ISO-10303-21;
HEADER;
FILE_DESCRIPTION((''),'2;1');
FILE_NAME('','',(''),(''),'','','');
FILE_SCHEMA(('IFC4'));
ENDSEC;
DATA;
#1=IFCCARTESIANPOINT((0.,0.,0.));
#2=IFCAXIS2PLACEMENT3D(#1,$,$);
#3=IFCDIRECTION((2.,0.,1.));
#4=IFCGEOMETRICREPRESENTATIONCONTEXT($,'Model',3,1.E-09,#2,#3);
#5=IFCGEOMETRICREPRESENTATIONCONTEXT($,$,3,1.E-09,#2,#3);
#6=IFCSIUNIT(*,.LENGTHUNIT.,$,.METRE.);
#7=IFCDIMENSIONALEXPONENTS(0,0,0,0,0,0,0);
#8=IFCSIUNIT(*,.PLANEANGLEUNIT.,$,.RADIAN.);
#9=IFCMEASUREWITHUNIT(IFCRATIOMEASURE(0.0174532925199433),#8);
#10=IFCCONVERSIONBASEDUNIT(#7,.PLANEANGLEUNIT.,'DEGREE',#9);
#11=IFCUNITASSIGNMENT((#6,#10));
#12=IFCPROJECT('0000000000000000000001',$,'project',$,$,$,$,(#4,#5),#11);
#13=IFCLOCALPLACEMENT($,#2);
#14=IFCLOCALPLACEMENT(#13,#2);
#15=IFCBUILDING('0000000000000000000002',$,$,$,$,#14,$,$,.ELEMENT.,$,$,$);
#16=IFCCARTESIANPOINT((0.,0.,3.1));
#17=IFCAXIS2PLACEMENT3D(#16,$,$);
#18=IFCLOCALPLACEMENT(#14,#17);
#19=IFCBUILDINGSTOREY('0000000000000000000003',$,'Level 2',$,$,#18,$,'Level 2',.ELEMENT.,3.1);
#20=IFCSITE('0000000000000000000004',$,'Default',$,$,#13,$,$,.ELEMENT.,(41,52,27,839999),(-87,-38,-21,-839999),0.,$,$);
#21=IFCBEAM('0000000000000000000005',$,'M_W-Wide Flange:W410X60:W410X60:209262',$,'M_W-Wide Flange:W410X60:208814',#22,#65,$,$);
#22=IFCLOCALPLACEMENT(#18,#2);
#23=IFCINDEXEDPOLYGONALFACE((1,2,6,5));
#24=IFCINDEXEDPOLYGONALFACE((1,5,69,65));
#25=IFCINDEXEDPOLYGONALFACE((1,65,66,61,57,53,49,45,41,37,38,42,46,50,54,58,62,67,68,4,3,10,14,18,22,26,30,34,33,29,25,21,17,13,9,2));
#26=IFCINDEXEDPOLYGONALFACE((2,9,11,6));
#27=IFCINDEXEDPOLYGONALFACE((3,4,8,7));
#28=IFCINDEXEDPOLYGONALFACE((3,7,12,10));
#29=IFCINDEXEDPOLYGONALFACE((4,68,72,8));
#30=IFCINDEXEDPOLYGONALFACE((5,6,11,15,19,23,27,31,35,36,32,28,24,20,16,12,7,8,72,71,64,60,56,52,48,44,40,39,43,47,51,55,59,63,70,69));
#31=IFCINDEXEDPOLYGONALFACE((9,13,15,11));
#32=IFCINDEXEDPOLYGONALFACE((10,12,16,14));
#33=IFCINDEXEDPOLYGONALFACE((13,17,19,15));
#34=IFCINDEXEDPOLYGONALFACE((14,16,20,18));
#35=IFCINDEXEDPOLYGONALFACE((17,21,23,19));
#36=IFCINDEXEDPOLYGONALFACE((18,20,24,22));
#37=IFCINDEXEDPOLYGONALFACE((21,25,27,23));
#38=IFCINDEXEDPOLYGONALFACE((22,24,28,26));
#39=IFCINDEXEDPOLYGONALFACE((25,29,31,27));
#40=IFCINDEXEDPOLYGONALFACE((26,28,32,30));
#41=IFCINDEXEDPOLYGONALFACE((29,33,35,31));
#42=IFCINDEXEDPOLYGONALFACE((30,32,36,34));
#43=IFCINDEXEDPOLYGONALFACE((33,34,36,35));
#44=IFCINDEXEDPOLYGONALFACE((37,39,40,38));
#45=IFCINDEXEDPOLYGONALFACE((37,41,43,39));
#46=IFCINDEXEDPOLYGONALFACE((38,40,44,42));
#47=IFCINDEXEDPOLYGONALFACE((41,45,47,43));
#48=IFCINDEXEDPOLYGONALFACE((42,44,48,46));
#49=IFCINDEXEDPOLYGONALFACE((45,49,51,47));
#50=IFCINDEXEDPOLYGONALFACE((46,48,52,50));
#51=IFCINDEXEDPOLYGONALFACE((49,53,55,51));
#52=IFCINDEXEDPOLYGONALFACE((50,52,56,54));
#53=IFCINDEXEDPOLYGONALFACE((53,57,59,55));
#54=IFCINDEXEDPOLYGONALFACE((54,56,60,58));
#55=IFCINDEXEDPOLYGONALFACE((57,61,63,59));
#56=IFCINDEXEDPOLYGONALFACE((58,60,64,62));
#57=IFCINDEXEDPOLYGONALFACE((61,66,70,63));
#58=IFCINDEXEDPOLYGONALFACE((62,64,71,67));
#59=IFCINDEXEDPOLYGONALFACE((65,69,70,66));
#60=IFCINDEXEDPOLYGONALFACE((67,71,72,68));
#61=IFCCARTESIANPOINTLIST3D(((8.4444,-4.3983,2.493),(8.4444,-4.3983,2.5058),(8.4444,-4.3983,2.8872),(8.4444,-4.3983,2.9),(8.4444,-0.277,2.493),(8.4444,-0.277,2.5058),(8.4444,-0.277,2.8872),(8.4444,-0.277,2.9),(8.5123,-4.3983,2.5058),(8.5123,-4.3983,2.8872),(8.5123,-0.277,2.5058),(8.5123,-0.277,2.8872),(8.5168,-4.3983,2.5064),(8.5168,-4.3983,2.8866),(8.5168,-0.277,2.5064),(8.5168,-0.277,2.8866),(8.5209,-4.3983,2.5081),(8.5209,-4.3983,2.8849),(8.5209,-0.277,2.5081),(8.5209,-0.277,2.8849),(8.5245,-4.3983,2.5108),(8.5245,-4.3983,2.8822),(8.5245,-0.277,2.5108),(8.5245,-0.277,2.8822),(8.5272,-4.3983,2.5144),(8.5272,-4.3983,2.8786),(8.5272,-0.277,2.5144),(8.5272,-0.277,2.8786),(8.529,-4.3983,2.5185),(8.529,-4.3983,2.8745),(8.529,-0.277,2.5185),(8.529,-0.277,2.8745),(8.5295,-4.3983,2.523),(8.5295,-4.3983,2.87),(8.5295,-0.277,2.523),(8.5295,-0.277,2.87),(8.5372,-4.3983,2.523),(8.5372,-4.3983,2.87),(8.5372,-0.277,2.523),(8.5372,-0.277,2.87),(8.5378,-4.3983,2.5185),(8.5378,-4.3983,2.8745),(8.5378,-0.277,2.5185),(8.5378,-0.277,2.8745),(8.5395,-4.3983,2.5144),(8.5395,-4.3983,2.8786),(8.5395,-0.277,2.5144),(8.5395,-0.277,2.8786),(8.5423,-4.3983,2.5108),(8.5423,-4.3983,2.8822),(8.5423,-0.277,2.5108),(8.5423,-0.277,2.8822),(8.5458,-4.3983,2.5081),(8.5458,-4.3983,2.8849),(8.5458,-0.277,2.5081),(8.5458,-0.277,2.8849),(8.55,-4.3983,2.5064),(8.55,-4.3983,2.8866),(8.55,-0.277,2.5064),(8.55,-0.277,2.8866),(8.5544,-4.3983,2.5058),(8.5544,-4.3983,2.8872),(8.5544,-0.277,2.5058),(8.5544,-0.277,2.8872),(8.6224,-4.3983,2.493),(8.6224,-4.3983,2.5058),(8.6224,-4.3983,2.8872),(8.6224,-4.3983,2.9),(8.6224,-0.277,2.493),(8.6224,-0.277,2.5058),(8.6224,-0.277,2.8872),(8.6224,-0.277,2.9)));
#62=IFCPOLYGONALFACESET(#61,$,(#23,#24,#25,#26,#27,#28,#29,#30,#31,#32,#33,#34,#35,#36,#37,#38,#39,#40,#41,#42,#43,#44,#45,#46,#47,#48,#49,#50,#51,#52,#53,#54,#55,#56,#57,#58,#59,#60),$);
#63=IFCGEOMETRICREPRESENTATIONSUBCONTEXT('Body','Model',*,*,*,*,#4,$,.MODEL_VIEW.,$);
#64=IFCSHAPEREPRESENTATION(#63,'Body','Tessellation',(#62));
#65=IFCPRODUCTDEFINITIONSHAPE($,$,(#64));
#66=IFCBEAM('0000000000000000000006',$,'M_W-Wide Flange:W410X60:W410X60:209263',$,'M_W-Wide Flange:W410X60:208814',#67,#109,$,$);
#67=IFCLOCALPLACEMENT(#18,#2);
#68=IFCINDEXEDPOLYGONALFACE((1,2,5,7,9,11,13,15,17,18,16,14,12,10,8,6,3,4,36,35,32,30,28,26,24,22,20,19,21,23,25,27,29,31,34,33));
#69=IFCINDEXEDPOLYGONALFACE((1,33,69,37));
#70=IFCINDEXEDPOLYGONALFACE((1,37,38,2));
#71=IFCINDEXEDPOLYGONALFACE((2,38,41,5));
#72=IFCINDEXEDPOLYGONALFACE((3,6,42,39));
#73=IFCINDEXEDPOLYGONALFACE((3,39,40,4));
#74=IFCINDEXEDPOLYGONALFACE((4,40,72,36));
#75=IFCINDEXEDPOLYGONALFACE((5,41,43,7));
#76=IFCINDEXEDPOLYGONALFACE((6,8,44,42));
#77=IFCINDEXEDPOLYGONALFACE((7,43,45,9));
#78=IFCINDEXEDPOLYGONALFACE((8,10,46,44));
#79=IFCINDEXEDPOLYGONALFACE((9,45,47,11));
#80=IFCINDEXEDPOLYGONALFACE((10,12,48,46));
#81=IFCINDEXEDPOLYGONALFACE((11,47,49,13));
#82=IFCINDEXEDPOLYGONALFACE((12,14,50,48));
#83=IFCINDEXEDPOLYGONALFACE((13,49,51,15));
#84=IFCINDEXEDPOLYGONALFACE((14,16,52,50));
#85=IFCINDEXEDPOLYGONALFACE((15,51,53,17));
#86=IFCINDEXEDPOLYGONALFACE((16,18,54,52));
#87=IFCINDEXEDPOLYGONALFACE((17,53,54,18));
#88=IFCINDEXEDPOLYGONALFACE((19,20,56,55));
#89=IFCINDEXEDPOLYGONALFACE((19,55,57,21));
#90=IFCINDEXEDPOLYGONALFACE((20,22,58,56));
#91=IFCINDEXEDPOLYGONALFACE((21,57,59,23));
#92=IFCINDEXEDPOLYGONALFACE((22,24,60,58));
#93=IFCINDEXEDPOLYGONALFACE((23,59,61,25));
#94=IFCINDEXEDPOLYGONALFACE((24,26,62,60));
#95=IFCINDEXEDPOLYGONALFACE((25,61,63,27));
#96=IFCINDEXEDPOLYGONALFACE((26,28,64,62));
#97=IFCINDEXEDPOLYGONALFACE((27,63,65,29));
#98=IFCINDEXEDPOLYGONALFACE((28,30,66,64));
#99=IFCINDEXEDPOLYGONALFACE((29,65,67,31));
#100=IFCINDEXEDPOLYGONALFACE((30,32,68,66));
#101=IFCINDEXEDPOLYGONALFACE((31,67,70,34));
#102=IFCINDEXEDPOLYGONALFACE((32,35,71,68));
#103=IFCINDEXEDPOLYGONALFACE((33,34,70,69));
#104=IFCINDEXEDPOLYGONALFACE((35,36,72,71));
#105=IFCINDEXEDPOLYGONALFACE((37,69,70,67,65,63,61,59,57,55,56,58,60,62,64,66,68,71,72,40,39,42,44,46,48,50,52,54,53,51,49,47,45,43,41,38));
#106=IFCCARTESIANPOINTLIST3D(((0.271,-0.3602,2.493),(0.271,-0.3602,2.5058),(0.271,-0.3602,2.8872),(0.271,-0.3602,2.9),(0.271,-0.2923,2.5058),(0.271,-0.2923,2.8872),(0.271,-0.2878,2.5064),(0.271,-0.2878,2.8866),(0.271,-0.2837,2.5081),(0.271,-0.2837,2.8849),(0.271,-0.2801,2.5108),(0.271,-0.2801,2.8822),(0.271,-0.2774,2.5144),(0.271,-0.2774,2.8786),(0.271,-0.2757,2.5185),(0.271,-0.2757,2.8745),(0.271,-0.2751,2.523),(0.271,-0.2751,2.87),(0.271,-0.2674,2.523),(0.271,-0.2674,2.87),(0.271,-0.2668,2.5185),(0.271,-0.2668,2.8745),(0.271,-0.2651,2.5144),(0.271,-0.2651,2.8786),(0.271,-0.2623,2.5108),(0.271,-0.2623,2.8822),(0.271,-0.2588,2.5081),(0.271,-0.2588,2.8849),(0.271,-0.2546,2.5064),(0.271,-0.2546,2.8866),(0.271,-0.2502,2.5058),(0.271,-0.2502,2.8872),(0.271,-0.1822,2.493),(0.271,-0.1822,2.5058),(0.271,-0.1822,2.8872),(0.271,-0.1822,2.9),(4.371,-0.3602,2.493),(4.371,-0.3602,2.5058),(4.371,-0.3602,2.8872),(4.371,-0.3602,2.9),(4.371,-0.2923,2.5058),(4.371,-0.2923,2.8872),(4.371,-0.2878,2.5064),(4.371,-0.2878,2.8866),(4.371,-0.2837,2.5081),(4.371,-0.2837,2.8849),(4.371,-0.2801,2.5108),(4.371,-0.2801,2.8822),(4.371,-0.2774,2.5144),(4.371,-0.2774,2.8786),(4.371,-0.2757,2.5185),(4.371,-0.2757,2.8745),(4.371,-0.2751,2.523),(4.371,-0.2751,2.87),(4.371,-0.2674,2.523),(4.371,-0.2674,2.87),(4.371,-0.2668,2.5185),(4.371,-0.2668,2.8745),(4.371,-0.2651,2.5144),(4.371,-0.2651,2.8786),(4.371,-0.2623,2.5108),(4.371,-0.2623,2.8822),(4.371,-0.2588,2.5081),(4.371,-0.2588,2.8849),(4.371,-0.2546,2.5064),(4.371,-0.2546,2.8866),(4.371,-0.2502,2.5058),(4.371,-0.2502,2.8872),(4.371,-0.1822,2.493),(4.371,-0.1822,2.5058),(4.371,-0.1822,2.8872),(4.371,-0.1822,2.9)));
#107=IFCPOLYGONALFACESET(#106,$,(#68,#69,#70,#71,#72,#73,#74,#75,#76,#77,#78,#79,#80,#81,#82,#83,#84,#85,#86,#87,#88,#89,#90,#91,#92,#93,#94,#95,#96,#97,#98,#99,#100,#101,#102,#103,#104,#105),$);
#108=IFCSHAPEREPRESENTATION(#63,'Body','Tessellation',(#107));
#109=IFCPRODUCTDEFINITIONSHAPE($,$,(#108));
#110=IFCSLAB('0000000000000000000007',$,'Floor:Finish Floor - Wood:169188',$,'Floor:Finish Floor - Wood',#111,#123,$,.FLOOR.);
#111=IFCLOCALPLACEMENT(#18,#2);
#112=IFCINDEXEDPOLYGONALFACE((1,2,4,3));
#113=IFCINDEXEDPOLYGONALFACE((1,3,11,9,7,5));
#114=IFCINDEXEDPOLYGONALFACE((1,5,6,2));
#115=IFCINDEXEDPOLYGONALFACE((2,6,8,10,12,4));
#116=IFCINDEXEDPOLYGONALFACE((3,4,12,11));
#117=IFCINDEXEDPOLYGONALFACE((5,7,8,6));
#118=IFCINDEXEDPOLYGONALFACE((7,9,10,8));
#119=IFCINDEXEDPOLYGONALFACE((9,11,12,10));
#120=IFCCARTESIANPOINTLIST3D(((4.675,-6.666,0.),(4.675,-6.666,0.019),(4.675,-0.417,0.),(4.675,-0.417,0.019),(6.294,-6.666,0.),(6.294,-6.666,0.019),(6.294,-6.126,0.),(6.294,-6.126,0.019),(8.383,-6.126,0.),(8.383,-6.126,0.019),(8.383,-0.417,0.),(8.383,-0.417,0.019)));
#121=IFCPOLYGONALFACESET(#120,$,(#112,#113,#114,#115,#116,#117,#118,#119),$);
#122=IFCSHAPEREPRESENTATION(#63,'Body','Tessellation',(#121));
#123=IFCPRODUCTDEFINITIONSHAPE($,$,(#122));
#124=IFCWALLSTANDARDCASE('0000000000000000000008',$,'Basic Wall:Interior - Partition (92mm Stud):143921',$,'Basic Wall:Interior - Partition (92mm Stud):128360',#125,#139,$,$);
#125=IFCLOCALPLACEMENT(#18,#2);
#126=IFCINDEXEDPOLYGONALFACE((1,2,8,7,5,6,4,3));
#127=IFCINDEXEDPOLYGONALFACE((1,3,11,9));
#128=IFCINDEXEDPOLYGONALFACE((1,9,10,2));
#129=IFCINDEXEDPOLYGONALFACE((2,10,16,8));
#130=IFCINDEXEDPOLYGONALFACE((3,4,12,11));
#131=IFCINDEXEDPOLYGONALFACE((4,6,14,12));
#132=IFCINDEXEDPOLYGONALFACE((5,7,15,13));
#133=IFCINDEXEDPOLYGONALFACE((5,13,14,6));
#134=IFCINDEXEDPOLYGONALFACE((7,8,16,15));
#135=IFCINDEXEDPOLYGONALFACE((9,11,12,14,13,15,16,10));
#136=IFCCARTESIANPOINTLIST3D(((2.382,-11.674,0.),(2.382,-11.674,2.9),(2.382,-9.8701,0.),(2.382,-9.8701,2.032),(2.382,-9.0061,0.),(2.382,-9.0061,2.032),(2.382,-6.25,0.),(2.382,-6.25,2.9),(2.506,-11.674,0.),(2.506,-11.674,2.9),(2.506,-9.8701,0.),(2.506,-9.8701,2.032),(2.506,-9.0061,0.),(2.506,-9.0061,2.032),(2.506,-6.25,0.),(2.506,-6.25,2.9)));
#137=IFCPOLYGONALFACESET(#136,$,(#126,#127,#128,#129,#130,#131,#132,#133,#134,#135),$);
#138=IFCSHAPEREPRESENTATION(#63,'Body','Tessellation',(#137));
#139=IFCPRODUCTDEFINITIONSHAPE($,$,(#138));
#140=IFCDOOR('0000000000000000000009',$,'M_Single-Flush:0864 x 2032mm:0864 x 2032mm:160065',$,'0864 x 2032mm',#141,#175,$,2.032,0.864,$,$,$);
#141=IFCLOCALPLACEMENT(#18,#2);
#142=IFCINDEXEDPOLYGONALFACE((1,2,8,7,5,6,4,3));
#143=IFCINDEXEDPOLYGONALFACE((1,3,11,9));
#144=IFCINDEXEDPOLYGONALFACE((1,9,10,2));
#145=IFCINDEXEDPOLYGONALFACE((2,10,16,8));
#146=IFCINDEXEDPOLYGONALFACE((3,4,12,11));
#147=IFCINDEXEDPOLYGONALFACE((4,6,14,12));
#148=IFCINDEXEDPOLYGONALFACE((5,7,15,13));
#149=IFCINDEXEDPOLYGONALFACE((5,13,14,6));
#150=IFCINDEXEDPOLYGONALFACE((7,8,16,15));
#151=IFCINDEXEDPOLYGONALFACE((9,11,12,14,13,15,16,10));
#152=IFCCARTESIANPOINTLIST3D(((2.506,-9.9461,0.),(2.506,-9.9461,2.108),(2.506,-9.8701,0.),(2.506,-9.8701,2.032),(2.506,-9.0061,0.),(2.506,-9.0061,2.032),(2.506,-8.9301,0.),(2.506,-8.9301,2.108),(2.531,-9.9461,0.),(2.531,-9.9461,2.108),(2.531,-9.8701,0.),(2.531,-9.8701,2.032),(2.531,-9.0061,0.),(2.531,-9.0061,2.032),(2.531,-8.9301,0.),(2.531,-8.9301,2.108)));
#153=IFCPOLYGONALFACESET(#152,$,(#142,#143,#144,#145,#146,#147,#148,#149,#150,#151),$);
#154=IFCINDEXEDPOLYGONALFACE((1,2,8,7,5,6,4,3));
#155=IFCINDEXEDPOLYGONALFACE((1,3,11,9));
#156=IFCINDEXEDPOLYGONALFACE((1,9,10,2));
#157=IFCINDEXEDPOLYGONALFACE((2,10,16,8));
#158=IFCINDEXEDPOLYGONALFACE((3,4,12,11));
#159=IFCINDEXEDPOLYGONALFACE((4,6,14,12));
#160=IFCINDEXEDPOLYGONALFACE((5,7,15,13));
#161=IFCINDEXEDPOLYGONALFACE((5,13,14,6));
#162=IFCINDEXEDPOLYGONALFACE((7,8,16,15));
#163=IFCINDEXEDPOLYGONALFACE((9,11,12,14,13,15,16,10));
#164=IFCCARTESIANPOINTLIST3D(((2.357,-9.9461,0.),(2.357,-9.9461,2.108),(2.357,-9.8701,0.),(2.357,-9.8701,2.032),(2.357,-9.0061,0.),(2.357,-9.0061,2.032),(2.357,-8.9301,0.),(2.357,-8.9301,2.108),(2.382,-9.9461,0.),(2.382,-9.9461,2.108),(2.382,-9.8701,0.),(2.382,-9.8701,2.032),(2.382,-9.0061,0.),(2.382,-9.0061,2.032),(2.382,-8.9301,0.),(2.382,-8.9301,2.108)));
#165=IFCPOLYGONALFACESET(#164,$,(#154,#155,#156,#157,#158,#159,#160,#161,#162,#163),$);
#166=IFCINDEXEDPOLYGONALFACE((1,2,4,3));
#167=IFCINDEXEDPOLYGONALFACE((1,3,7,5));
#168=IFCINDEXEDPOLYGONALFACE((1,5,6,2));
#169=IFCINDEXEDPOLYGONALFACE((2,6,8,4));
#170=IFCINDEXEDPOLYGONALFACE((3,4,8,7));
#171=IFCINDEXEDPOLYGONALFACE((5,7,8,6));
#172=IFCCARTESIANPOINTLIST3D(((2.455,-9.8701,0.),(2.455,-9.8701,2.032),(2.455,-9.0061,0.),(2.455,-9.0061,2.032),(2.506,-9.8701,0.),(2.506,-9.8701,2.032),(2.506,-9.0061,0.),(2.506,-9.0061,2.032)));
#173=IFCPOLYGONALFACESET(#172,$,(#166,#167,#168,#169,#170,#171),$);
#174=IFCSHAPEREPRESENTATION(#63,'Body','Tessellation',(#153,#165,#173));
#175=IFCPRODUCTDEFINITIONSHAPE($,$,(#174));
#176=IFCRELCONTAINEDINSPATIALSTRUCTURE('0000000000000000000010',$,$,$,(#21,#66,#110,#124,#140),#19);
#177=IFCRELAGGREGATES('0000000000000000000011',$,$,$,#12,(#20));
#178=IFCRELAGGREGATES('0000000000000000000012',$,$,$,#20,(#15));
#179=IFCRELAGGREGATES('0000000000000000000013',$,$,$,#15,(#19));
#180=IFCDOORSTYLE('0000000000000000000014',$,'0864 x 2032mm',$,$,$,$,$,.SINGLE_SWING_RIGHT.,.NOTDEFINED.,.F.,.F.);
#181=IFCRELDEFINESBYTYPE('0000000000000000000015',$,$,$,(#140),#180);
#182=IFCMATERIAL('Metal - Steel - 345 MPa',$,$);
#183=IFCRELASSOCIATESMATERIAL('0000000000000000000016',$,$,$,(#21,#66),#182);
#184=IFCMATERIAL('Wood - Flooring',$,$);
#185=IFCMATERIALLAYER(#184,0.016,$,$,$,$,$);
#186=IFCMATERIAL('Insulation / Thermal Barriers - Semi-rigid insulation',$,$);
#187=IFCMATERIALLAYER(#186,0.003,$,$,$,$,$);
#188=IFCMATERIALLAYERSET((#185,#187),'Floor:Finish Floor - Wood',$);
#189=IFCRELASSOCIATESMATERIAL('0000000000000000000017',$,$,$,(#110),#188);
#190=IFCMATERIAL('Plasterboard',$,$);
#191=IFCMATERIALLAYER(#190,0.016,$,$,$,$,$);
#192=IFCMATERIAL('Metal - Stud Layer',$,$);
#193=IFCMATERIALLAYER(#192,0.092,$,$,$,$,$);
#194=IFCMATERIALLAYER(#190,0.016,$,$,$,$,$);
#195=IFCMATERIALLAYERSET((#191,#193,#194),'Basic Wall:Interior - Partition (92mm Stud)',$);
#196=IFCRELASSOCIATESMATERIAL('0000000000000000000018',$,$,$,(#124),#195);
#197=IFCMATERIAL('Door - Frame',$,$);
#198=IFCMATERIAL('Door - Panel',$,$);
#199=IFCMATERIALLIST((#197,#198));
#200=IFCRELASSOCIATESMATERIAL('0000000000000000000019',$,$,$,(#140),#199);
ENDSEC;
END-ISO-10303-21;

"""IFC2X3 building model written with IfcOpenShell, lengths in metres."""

from ifc_helpers import new_model, entity, si_unit, converted_unit, direction, frame, frame_2d, origin, origin_2d_with_axis, place, context, subcontext, project, spatial, polyline, rectangle, i_section, outline, extrude, source, transform, mapped, material, material_list, layer, layer_set, layer_usage, type_object, type_shapes, element, fill, save


model = new_model("IFC2X3")

# Units and contexts
model_context = context("Model", 3, precision=1e-09, world=origin(), true_north=direction((2.0, 0.0, 1.0)))
context_of_model = context(None, 3, precision=1e-09, world=origin(), true_north=direction((2.0, 0.0, 1.0)))
body_context = subcontext(model_context, "Body", "Model", "MODEL_VIEW")
ifc_project = project(units=[si_unit("LENGTHUNIT", "METRE"), converted_unit("PLANEANGLEUNIT", "DEGREE", entity("IfcRatioMeasure", 0.0174532925199433), si_unit("PLANEANGLEUNIT", "RADIAN"), dimensions=[0, 0, 0, 0, 0, 0, 0])], contexts=[model_context, context_of_model])

# Site, building, storey
site_placement = place(None, origin())
site = spatial("IfcSite", under=ifc_project, at=site_placement, Name="Default", CompositionType="ELEMENT", RefLatitude=(41, 52, 27, 839999), RefLongitude=(-87, -38, -21, -839999), RefElevation=0.0)
building_placement = place(site_placement, origin())
building = spatial("IfcBuilding", under=site, at=building_placement, CompositionType="ELEMENT")
storey_placement = place(building_placement, frame((0.0, 0.0, 3.1)))
storey = spatial("IfcBuildingStorey", under=building, at=storey_placement, Name="Level 2", LongName="Level 2", CompositionType="ELEMENT", Elevation=3.1)

# Beams
ifc_material_1 = material(Name="Metal - Steel - 345 MPa")
beam_1_placement = place(storey_placement, frame((8.5334, -4.3983, 2.9), z_axis=(0.0, 0.0, 1.0), x_axis=(0.0, 1.0, 0.0)))
element("IfcBeam", 1, at=beam_1_placement, inside=storey, material=ifc_material_1, Name="M_W-Wide Flange:W410X60:W410X60:209262", ObjectType="M_W-Wide Flange:W410X60:208814", context=body_context, shape_type="SweptSolid", body=[
    extrude(i_section(OverallWidth=0.178, OverallDepth=0.407, WebThickness=0.0077, FlangeThickness=0.0128, FilletRadius=0.0172, at=frame_2d((0.0, 0.0), x_axis=(1.0, 0.0))), frame((0.0, 0.0, -0.2035), z_axis=(-1.0, 0.0, 0.0), x_axis=(0.0, -1.0, 0.0)), (0.0, 0.0, -1.0), 4.1213),
])
beam_2_placement = place(storey_placement, frame((4.371, -0.2712, 2.9), z_axis=(0.0, 0.0, 1.0), x_axis=(-1.0, 0.0, 0.0)))
element("IfcBeam", 2, at=beam_2_placement, inside=storey, material=ifc_material_1, Name="M_W-Wide Flange:W410X60:W410X60:209263", ObjectType="M_W-Wide Flange:W410X60:208814", context=body_context, shape_type="SweptSolid", body=[
    extrude(i_section(OverallWidth=0.178, OverallDepth=0.407, WebThickness=0.0077, FlangeThickness=0.0128, FilletRadius=0.0172, at=origin_2d_with_axis()), frame((0.0, 0.0, -0.2035), z_axis=(-1.0, 0.0, 0.0), x_axis=(0.0, -1.0, 0.0)), (0.0, 0.0, -1.0), 4.1),
])

# Slab
ifc_material_2 = material(Name="Wood - Flooring")
ifc_layer_1 = layer(ifc_material_2, 0.016)
ifc_material_3 = material(Name="Insulation / Thermal Barriers - Semi-rigid insulation")
ifc_layer_2 = layer(ifc_material_3, 0.003)
ifc_layer_set_1 = layer_set([ifc_layer_1, ifc_layer_2], Name="Floor:Finish Floor - Wood")
ifc_layer_usage_1 = layer_usage(ifc_layer_set_1, "AXIS3", "POSITIVE", 0.0)
slab_placement = place(storey_placement, frame((4.675, -6.666, 0.0)))
element("IfcSlab", 3, at=slab_placement, inside=storey, material=ifc_layer_usage_1, Name="Floor:Finish Floor - Wood:169188", ObjectType="Floor:Finish Floor - Wood", PredefinedType="FLOOR", context=body_context, shape_type="SweptSolid", body=[
    extrude(outline(polyline([(-1.854, 3.1245), (-1.854, -2.5845), (0.235, -2.5845), (0.235, -3.1245), (1.854, -3.1245), (1.854, 3.1245), (-1.854, 3.1245)])), frame((1.854, 3.1245, 0.019), z_axis=(0.0, 0.0, -1.0), x_axis=(-1.0, 0.0, 0.0)), (0.0, 0.0, 1.0), 0.019),
])

# Shared definitions
ifc_material_4 = material(Name="Metal - Stud Layer")
ifc_material_5 = material(Name="Plasterboard")

# Wall, opening, door
ifc_layer_3 = layer(ifc_material_5, 0.016)
ifc_layer_4 = layer(ifc_material_4, 0.092)
ifc_layer_5 = layer(ifc_material_5, 0.016)
ifc_layer_set_2 = layer_set([ifc_layer_3, ifc_layer_4, ifc_layer_5], Name="Basic Wall:Interior - Partition (92mm Stud)")
ifc_layer_usage_2 = layer_usage(ifc_layer_set_2, "AXIS2", "NEGATIVE", 0.062)
wall_1_placement = place(storey_placement, frame((2.444, -6.25, 0.0), z_axis=(0.0, 0.0, 1.0), x_axis=(0.0, -1.0, 0.0)))
wall_1 = element("IfcWallStandardCase", 4, at=wall_1_placement, inside=storey, material=ifc_layer_usage_2, Name="Basic Wall:Interior - Partition (92mm Stud):143921", ObjectType="Basic Wall:Interior - Partition (92mm Stud):128360", context=body_context, shape_type="SweptSolid", body=[
    extrude(rectangle(XDim=5.424, YDim=0.124, at=frame_2d((2.712, 0.0), x_axis=(-1.0, 0.0))), origin(), (0.0, 0.0, 1.0), 2.9),
])
opening_1_placement = place(wall_1_placement, frame((2.7561, -0.062, 0.0)))
opening_1 = element("IfcOpeningElement", 5, at=opening_1_placement, cuts=wall_1, ObjectType="Opening", context=body_context, shape_type="SweptSolid", body=[
    extrude(rectangle(XDim=0.864, YDim=2.032, at=frame_2d((1.016, 0.432), x_axis=(0.0, 1.0))), frame((0.0, 0.0, 0.0), z_axis=(0.0, 1.0, 0.0), x_axis=(0.0, 0.0, 1.0)), (0.0, 0.0, 1.0), 0.124),
])
ifc_material_6 = material(Name="Door - Frame")
ifc_material_7 = material(Name="Door - Panel")
ifc_material_list_1 = material_list([ifc_material_6, ifc_material_7])
door_style_1 = type_object("IfcDoorStyle", Name="0864 x 2032mm", ConstructionType="NOTDEFINED", OperationType="SINGLE_SWING_RIGHT", ParameterTakesPrecedence=False, Sizeable=False)
shared_shape_1 = source(origin(), body_context, "Body", "SweptSolid", [
    extrude(outline(polyline([(-0.508, -1.073), (0.508, -1.073), (0.508, 1.035), (0.432, 1.035), (0.432, -0.997), (-0.432, -0.997), (-0.432, 1.035), (-0.508, 1.035), (-0.508, -1.073)])), frame((0.432, 0.124, 1.035), z_axis=(0.0, 1.0, 0.0), x_axis=(1.0, 0.0, 0.0)), (0.0, 0.0, 1.0), 0.025),
    extrude(outline(polyline([(-1.073, -0.508), (1.035, -0.508), (1.035, -0.432), (-0.997, -0.432), (-0.997, 0.432), (1.035, 0.432), (1.035, 0.508), (-1.073, 0.508), (-1.073, -0.508)])), frame((0.432, -0.025, 1.035), z_axis=(0.0, 1.0, 0.0), x_axis=(0.0, 0.0, -1.0)), (0.0, 0.0, 1.0), 0.025),
    extrude(rectangle(XDim=0.051, YDim=0.864, at=origin_2d_with_axis()), frame((0.432, 0.0985, 0.0), z_axis=(0.0, 0.0, 1.0), x_axis=(0.0, 1.0, 0.0)), (0.0, 0.0, 1.0), 2.032),
])
type_shapes(door_style_1, [shared_shape_1])
door_1_placement = place(opening_1_placement, origin())
door_1 = element("IfcDoor", 6, at=door_1_placement, inside=storey, type_object=door_style_1, material=ifc_material_list_1, Name="M_Single-Flush:0864 x 2032mm:0864 x 2032mm:160065", ObjectType="0864 x 2032mm", OverallHeight=2.032, OverallWidth=0.864, context=body_context, shape_type="MappedRepresentation", body=[
    mapped(shared_shape_1, transform((0.0, 0.0, 0.0), scale=1.0)),
])
fill(opening_1, door_1)

save(model, "model.ifc")
